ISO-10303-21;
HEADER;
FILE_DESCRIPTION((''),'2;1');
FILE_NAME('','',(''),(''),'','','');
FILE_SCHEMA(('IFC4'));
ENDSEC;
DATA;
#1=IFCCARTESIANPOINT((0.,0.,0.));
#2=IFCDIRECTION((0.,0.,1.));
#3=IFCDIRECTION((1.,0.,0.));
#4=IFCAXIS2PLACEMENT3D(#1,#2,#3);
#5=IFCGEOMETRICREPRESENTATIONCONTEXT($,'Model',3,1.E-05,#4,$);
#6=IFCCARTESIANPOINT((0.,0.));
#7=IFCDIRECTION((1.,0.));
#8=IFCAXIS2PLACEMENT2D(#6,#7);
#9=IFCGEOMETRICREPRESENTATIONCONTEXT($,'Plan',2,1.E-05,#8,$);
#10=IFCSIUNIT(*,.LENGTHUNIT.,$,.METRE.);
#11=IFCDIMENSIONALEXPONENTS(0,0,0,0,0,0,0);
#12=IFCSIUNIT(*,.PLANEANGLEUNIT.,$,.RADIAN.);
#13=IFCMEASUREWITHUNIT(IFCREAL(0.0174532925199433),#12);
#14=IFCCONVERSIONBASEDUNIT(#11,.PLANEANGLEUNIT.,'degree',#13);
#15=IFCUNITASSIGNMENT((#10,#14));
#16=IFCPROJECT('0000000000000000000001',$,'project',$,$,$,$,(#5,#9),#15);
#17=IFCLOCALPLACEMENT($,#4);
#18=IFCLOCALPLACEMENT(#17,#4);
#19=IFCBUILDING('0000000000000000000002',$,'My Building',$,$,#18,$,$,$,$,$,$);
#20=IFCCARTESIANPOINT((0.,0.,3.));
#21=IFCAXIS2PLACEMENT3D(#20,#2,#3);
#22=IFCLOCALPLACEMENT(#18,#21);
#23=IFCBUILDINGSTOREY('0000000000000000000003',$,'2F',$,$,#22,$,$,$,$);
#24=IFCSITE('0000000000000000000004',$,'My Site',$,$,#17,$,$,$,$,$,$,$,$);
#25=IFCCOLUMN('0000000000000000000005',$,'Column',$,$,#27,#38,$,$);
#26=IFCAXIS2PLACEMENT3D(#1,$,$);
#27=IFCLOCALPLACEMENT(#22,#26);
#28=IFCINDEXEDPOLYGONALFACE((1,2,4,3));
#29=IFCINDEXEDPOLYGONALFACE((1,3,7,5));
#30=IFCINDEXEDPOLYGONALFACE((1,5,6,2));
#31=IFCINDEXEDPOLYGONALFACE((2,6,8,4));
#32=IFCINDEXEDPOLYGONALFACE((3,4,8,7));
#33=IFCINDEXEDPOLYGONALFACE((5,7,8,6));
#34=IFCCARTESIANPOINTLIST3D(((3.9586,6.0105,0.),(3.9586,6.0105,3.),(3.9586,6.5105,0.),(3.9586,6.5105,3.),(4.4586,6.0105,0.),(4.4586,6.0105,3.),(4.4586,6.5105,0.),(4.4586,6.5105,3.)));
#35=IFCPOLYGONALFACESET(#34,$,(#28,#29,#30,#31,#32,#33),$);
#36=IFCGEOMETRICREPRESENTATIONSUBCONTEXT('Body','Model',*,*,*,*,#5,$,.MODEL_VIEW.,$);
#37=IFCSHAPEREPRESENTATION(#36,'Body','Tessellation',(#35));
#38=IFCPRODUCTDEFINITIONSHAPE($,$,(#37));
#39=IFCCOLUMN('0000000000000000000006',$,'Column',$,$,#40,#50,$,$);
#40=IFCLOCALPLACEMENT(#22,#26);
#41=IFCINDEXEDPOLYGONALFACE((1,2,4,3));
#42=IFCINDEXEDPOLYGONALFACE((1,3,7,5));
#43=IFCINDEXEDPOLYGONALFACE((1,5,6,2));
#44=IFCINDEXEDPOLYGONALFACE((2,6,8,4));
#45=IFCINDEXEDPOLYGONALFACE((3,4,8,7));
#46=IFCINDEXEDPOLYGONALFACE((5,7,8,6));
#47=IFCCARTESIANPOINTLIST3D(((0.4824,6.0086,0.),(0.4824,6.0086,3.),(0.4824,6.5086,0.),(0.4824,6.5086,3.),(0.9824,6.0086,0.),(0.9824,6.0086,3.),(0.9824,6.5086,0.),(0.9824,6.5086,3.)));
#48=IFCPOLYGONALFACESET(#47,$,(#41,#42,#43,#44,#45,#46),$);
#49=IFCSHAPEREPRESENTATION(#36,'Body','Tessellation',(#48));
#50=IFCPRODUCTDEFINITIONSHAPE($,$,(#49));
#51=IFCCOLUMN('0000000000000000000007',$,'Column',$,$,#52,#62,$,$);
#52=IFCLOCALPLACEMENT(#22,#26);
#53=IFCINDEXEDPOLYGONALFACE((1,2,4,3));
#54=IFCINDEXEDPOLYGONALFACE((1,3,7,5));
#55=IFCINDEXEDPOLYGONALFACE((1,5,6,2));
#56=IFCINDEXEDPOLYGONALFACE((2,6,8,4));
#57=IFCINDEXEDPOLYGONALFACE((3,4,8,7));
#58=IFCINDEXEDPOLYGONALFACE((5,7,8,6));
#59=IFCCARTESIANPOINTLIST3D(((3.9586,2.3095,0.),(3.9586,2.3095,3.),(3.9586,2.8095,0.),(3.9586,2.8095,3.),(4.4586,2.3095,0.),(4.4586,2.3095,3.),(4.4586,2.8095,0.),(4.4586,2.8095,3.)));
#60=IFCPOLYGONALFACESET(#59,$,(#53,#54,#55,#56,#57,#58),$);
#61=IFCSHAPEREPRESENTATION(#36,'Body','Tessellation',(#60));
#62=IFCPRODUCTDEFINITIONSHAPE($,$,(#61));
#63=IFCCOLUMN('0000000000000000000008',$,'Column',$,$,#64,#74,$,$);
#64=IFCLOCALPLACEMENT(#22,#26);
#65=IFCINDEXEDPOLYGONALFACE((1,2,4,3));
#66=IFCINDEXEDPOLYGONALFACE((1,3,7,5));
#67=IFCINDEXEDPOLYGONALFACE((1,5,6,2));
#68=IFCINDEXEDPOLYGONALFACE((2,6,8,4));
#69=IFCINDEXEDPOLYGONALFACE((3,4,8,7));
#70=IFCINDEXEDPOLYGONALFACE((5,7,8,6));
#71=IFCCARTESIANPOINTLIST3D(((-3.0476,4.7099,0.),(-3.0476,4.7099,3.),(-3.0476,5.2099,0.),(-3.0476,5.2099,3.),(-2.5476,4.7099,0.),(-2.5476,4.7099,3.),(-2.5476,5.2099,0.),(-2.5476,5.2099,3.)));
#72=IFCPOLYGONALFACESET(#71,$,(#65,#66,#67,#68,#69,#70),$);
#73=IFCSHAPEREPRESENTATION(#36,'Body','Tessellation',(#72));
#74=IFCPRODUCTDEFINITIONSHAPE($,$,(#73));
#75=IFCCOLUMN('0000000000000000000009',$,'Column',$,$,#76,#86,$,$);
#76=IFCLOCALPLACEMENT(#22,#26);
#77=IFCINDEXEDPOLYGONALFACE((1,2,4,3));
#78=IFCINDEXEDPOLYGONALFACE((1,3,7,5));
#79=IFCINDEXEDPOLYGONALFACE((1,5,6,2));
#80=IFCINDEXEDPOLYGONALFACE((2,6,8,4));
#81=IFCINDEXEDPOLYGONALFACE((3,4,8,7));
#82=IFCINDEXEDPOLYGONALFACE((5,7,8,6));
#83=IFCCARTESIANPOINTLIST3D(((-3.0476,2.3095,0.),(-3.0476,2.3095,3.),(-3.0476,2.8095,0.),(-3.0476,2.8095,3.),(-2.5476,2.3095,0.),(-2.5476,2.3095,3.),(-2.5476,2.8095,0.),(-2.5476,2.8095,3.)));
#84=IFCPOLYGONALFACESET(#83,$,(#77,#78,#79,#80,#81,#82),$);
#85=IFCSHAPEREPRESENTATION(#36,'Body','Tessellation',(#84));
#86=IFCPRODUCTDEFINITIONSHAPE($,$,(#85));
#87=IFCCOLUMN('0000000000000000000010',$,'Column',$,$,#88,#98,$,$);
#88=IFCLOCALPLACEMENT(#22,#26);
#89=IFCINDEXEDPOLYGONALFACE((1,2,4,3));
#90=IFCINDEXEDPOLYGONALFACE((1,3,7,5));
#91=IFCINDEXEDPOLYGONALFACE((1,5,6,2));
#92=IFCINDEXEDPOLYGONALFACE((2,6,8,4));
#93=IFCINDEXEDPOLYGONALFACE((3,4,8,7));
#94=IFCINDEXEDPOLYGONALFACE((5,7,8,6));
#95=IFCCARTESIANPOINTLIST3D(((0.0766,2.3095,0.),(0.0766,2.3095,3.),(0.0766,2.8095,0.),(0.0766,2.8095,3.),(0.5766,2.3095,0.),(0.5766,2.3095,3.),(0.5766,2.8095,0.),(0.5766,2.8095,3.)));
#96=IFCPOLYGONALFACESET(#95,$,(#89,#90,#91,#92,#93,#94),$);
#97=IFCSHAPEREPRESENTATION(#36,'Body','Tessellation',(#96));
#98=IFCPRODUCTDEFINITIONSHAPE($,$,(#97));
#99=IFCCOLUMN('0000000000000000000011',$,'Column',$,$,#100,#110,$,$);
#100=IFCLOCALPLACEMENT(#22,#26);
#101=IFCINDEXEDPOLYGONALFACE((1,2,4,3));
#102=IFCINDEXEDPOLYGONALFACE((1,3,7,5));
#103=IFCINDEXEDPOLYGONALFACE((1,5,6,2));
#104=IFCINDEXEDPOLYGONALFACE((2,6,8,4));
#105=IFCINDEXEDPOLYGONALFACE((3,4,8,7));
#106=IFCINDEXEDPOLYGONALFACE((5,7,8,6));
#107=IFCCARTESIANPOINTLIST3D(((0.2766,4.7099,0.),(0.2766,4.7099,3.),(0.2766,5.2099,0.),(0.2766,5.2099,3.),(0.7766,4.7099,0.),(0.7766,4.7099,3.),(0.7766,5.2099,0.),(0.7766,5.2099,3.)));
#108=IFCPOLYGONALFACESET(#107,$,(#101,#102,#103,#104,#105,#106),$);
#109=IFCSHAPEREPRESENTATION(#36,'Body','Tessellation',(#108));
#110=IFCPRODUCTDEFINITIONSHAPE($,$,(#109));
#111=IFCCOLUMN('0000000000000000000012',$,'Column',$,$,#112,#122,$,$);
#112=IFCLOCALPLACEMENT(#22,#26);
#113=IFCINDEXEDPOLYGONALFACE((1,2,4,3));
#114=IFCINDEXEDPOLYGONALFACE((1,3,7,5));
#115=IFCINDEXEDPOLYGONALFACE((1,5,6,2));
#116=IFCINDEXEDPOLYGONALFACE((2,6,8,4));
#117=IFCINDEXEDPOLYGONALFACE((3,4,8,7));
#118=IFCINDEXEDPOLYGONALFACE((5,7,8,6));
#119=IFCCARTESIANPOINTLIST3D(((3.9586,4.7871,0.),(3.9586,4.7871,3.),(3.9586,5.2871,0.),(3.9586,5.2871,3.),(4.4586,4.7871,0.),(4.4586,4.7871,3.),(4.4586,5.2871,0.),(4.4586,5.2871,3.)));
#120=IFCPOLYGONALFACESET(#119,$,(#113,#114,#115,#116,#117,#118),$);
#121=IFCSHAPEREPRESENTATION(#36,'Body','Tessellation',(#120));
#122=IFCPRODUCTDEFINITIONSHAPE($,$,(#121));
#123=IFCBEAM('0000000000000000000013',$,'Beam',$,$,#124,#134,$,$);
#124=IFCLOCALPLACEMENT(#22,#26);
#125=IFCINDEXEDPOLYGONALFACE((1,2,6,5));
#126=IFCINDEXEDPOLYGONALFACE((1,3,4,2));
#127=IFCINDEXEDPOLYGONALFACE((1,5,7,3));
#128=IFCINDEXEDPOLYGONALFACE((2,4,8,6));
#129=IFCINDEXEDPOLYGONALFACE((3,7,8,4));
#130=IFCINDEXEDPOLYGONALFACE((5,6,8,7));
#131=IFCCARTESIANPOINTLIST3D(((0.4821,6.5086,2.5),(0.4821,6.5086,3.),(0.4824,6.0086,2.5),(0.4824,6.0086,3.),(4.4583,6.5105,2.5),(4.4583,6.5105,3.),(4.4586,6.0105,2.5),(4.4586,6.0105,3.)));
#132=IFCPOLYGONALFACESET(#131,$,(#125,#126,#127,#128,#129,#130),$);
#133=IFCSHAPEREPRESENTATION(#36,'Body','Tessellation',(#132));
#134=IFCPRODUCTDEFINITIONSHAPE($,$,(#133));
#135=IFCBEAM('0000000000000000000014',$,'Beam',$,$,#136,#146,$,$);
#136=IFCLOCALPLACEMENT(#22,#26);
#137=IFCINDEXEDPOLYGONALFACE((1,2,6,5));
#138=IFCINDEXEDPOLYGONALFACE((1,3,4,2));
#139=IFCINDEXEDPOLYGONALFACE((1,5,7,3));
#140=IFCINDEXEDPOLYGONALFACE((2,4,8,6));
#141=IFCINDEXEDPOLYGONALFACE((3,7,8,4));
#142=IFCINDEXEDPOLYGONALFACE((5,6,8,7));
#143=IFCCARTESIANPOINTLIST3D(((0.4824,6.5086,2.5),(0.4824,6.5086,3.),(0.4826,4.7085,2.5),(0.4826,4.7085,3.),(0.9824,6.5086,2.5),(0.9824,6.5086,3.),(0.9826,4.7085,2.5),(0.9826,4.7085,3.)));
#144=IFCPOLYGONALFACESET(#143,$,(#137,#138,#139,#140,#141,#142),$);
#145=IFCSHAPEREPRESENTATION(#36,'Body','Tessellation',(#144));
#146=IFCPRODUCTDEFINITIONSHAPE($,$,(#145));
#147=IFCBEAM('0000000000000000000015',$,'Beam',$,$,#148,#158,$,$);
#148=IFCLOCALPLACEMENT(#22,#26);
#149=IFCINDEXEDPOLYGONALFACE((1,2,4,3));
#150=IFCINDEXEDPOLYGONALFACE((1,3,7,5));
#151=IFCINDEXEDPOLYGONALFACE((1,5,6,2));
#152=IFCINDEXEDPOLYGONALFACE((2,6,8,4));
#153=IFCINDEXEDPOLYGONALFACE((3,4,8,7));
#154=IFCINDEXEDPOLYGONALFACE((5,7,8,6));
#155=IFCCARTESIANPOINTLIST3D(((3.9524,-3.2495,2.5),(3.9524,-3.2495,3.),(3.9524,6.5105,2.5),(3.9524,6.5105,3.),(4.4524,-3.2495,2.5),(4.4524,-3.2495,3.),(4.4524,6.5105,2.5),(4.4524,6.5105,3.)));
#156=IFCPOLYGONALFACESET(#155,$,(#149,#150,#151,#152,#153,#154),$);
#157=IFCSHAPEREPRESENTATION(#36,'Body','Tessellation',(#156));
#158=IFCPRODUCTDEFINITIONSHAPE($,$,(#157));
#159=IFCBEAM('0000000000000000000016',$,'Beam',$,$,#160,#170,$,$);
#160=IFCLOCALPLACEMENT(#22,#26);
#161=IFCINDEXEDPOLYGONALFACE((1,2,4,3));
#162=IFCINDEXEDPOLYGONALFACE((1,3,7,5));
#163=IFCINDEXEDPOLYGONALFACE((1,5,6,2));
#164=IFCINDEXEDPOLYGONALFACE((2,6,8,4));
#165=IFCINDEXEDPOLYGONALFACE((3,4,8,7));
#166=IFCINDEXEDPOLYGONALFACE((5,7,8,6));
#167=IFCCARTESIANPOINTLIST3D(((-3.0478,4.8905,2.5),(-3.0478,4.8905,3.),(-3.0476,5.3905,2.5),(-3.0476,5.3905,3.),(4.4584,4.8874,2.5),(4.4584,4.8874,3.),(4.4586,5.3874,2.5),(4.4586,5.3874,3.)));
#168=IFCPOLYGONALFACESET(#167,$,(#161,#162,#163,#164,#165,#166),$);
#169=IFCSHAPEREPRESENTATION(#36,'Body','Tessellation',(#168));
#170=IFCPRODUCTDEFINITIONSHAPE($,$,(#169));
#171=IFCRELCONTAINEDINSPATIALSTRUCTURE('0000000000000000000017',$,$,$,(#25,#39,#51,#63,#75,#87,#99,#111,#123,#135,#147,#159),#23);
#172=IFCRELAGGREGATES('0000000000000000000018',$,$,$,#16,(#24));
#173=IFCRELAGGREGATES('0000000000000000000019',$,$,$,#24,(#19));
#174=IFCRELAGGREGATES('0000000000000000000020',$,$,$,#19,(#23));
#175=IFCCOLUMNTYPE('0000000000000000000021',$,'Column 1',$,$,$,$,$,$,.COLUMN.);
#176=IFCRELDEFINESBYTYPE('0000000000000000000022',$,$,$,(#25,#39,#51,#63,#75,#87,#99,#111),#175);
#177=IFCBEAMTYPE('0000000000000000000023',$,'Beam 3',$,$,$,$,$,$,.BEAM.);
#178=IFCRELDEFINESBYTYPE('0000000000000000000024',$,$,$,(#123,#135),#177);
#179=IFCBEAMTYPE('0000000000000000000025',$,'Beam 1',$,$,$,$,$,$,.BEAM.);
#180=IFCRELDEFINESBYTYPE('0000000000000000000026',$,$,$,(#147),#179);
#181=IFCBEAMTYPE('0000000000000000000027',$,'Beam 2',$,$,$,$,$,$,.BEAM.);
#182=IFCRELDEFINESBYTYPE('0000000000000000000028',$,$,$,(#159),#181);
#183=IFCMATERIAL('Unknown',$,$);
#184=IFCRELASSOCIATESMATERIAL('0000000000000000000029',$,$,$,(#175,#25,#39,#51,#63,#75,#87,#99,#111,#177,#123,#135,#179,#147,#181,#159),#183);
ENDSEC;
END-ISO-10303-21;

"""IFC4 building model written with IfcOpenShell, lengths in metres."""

from ifc_helpers import new_model, entity, si_unit, converted_unit, frame, origin_with_axes, origin_2d_with_axis, place, context, subcontext, project, spatial, indexed_curve, outline, extrude, material, material_profile, profile_set, profile_usage, type_object, element, save


model = new_model("IFC4")

# Units and contexts
model_context = context("Model", 3, precision=1e-05, world=origin_with_axes())
plan_context = context("Plan", 2, precision=1e-05, world=origin_2d_with_axis())
body_context_1 = subcontext(model_context, "Body", "Model", "MODEL_VIEW")
ifc_project = project(units=[si_unit("LENGTHUNIT", "METRE"), converted_unit("PLANEANGLEUNIT", "degree", entity("IfcReal", 0.0174532925199433), si_unit("PLANEANGLEUNIT", "RADIAN"), dimensions=[0, 0, 0, 0, 0, 0, 0])], contexts=[model_context, plan_context])

# Site, building, storey
site_placement = place(None, origin_with_axes())
site = spatial("IfcSite", under=ifc_project, at=site_placement, Name="My Site")
building_placement = place(site_placement, origin_with_axes())
building = spatial("IfcBuilding", under=site, at=building_placement, Name="My Building")
storey_placement = place(building_placement, frame((0.0, 0.0, 3.0), z_axis=(0.0, 0.0, 1.0), x_axis=(1.0, 0.0, 0.0)))
storey = spatial("IfcBuildingStorey", under=building, at=storey_placement, Name="2F")

# Columns
ifc_material = material(Name="Unknown")
ifc_material_profile_1 = material_profile(ifc_material, outline(indexed_curve([(-0.25, -0.25), (0.25, -0.25), (0.25, 0.25), (-0.25, 0.25), (-0.25, -0.25)])))
ifc_profile_set_1 = profile_set([ifc_material_profile_1])
ifc_profile_usage_1 = profile_usage(ifc_profile_set_1, cardinal=9)
column_type = type_object("IfcColumnType", Name="Column 1", PredefinedType="COLUMN", material=ifc_profile_set_1)
column_1_placement = place(storey_placement, frame((3.9586, 6.5105, 0.0), z_axis=(0.0, 0.0, 1.0), x_axis=(1.0, 0.0, 0.0)))
element("IfcColumn", 1, at=column_1_placement, inside=storey, type_object=column_type, material=ifc_profile_usage_1, Name="Column", context=body_context_1, shape_type="SweptSolid", body=[
    extrude(outline(indexed_curve([(-0.25, -0.25), (0.25, -0.25), (0.25, 0.25), (-0.25, 0.25), (-0.25, -0.25)])), frame((0.25, -0.25, 0.0), z_axis=(0.0, 0.0, 1.0), x_axis=(1.0, 0.0, 0.0)), (0.0, 0.0, 1.0), 3.0),
])
ifc_profile_usage_2 = profile_usage(ifc_profile_set_1, cardinal=9)
column_2_placement = place(storey_placement, frame((0.4824, 6.5086, 0.0), z_axis=(0.0, 0.0, 1.0), x_axis=(1.0, 0.0, 0.0)))
element("IfcColumn", 2, at=column_2_placement, inside=storey, type_object=column_type, material=ifc_profile_usage_2, Name="Column", context=body_context_1, shape_type="SweptSolid", body=[
    extrude(outline(indexed_curve([(-0.25, -0.25), (0.25, -0.25), (0.25, 0.25), (-0.25, 0.25), (-0.25, -0.25)])), frame((0.25, -0.25, 0.0), z_axis=(0.0, 0.0, 1.0), x_axis=(1.0, 0.0, 0.0)), (0.0, 0.0, 1.0), 3.0),
])
ifc_profile_usage_3 = profile_usage(ifc_profile_set_1, cardinal=9)
column_3_placement = place(storey_placement, frame((3.9586, 2.8095, 0.0), z_axis=(0.0, 0.0, 1.0), x_axis=(1.0, 0.0, 0.0)))
element("IfcColumn", 3, at=column_3_placement, inside=storey, type_object=column_type, material=ifc_profile_usage_3, Name="Column", context=body_context_1, shape_type="SweptSolid", body=[
    extrude(outline(indexed_curve([(-0.25, -0.25), (0.25, -0.25), (0.25, 0.25), (-0.25, 0.25), (-0.25, -0.25)])), frame((0.25, -0.25, 0.0), z_axis=(0.0, 0.0, 1.0), x_axis=(1.0, 0.0, 0.0)), (0.0, 0.0, 1.0), 3.0),
])
ifc_profile_usage_4 = profile_usage(ifc_profile_set_1, cardinal=7)
column_4_placement = place(storey_placement, frame((-2.5476, 5.2099, 0.0), z_axis=(0.0, 0.0, 1.0), x_axis=(1.0, 0.0, 0.0)))
element("IfcColumn", 4, at=column_4_placement, inside=storey, type_object=column_type, material=ifc_profile_usage_4, Name="Column", context=body_context_1, shape_type="SweptSolid", body=[
    extrude(outline(indexed_curve([(-0.25, -0.25), (0.25, -0.25), (0.25, 0.25), (-0.25, 0.25), (-0.25, -0.25)])), frame((-0.25, -0.25, 0.0), z_axis=(0.0, 0.0, 1.0), x_axis=(1.0, 0.0, 0.0)), (0.0, 0.0, 1.0), 3.0),
])
ifc_profile_usage_5 = profile_usage(ifc_profile_set_1, cardinal=7)
column_5_placement = place(storey_placement, frame((-2.5476, 2.8095, 0.0), z_axis=(0.0, 0.0, 1.0), x_axis=(1.0, 0.0, 0.0)))
element("IfcColumn", 5, at=column_5_placement, inside=storey, type_object=column_type, material=ifc_profile_usage_5, Name="Column", context=body_context_1, shape_type="SweptSolid", body=[
    extrude(outline(indexed_curve([(-0.25, -0.25), (0.25, -0.25), (0.25, 0.25), (-0.25, 0.25), (-0.25, -0.25)])), frame((-0.25, -0.25, 0.0), z_axis=(0.0, 0.0, 1.0), x_axis=(1.0, 0.0, 0.0)), (0.0, 0.0, 1.0), 3.0),
])
ifc_profile_usage_6 = profile_usage(ifc_profile_set_1, cardinal=9)
column_6_placement = place(storey_placement, frame((0.0766, 2.8095, 0.0), z_axis=(0.0, 0.0, 1.0), x_axis=(1.0, 0.0, 0.0)))
element("IfcColumn", 6, at=column_6_placement, inside=storey, type_object=column_type, material=ifc_profile_usage_6, Name="Column", context=body_context_1, shape_type="SweptSolid", body=[
    extrude(outline(indexed_curve([(-0.25, -0.25), (0.25, -0.25), (0.25, 0.25), (-0.25, 0.25), (-0.25, -0.25)])), frame((0.25, -0.25, 0.0), z_axis=(0.0, 0.0, 1.0), x_axis=(1.0, 0.0, 0.0)), (0.0, 0.0, 1.0), 3.0),
])
ifc_profile_usage_7 = profile_usage(ifc_profile_set_1, cardinal=9)
column_7_placement = place(storey_placement, frame((0.2766, 5.2099, 0.0), z_axis=(0.0, 0.0, 1.0), x_axis=(1.0, 0.0, 0.0)))
element("IfcColumn", 7, at=column_7_placement, inside=storey, type_object=column_type, material=ifc_profile_usage_7, Name="Column", context=body_context_1, shape_type="SweptSolid", body=[
    extrude(outline(indexed_curve([(-0.25, -0.25), (0.25, -0.25), (0.25, 0.25), (-0.25, 0.25), (-0.25, -0.25)])), frame((0.25, -0.25, 0.0), z_axis=(0.0, 0.0, 1.0), x_axis=(1.0, 0.0, 0.0)), (0.0, 0.0, 1.0), 3.0),
])
ifc_profile_usage_8 = profile_usage(ifc_profile_set_1, cardinal=9)
column_8_placement = place(storey_placement, frame((3.9586, 5.2871, 0.0), z_axis=(0.0, 0.0, 1.0), x_axis=(1.0, 0.0, 0.0)))
element("IfcColumn", 8, at=column_8_placement, inside=storey, type_object=column_type, material=ifc_profile_usage_8, Name="Column", context=body_context_1, shape_type="SweptSolid", body=[
    extrude(outline(indexed_curve([(-0.25, -0.25), (0.25, -0.25), (0.25, 0.25), (-0.25, 0.25), (-0.25, -0.25)])), frame((0.25, -0.25, 0.0), z_axis=(0.0, 0.0, 1.0), x_axis=(1.0, 0.0, 0.0)), (0.0, 0.0, 1.0), 3.0),
])

# Beams
ifc_material_profile_2 = material_profile(ifc_material, outline(indexed_curve([(-0.25, -0.25), (0.25, -0.25), (0.25, 0.25), (-0.25, 0.25), (-0.25, -0.25)])))
ifc_profile_set_2 = profile_set([ifc_material_profile_2])
ifc_profile_usage_9 = profile_usage(ifc_profile_set_2, cardinal=7)
beam_type_1 = type_object("IfcBeamType", Name="Beam 3", PredefinedType="BEAM", material=ifc_profile_set_2)
beam_1_placement = place(storey_placement, frame((4.4586, 6.0105, 3.0), z_axis=(-1.0, -0.000479, 0.0), x_axis=(0.000479, -1.0, 0.0)))
element("IfcBeam", 9, at=beam_1_placement, inside=storey, type_object=beam_type_1, material=ifc_profile_usage_9, Name="Beam", context=body_context_1, shape_type="SweptSolid", body=[
    extrude(outline(indexed_curve([(-0.25, -0.25), (0.25, -0.25), (0.25, 0.25), (-0.25, 0.25), (-0.25, -0.25)])), frame((-0.25, -0.25, 0.0), z_axis=(0.0, 0.0, 1.0), x_axis=(1.0, 0.0, 0.0)), (0.0, 0.0, 1.0), 3.9762),
])
ifc_profile_usage_10 = profile_usage(ifc_profile_set_2, cardinal=9)
beam_2_placement = place(storey_placement, frame((0.4824, 6.5086, 3.0), z_axis=(0.000106, -1.0, 0.000001), x_axis=(1.0, 0.000106, 0.0)))
element("IfcBeam", 10, at=beam_2_placement, inside=storey, type_object=beam_type_1, material=ifc_profile_usage_10, Name="Beam", context=body_context_1, shape_type="SweptSolid", body=[
    extrude(outline(indexed_curve([(-0.25, -0.25), (0.25, -0.25), (0.25, 0.25), (-0.25, 0.25), (-0.25, -0.25)])), frame((0.25, -0.25, 0.0), z_axis=(0.0, 0.0, 1.0), x_axis=(1.0, 0.0, 0.0)), (0.0, 0.0, 1.0), 1.8001),
])
ifc_material_profile_3 = material_profile(ifc_material, outline(indexed_curve([(-0.25, -0.25), (0.25, -0.25), (0.25, 0.25), (-0.25, 0.25), (-0.25, -0.25)])))
ifc_profile_set_3 = profile_set([ifc_material_profile_3])
ifc_profile_usage_11 = profile_usage(ifc_profile_set_3, cardinal=7)
beam_type_2 = type_object("IfcBeamType", Name="Beam 1", PredefinedType="BEAM", material=ifc_profile_set_3)
beam_3_placement = place(storey_placement, frame((4.4524, 6.5105, 3.0), z_axis=(0.0, -1.0, 0.0), x_axis=(1.0, 0.0, 0.0)))
element("IfcBeam", 11, at=beam_3_placement, inside=storey, type_object=beam_type_2, material=ifc_profile_usage_11, Name="Beam", context=body_context_1, shape_type="SweptSolid", body=[
    extrude(outline(indexed_curve([(-0.25, -0.25), (0.25, -0.25), (0.25, 0.25), (-0.25, 0.25), (-0.25, -0.25)])), frame((-0.25, -0.25, 0.0), z_axis=(0.0, 0.0, 1.0), x_axis=(1.0, 0.0, 0.0)), (0.0, 0.0, 1.0), 9.76),
])
ifc_material_profile_4 = material_profile(ifc_material, outline(indexed_curve([(-0.25, -0.25), (0.25, -0.25), (0.25, 0.25), (-0.25, 0.25), (-0.25, -0.25)])))
ifc_profile_set_4 = profile_set([ifc_material_profile_4])
ifc_profile_usage_12 = profile_usage(ifc_profile_set_4, cardinal=7)
beam_type_3 = type_object("IfcBeamType", Name="Beam 2", PredefinedType="BEAM", material=ifc_profile_set_4)
beam_4_placement = place(storey_placement, frame((-3.0476, 5.3905, 3.0), z_axis=(1.0, -0.000402, 0.0), x_axis=(0.000402, 1.0, 0.0)))
element("IfcBeam", 12, at=beam_4_placement, inside=storey, type_object=beam_type_3, material=ifc_profile_usage_12, Name="Beam", context=body_context_1, shape_type="SweptSolid", body=[
    extrude(outline(indexed_curve([(-0.25, -0.25), (0.25, -0.25), (0.25, 0.25), (-0.25, 0.25), (-0.25, -0.25)])), frame((-0.25, -0.25, 0.0), z_axis=(0.0, 0.0, 1.0), x_axis=(1.0, 0.0, 0.0)), (0.0, 0.0, 1.0), 7.5062),
])

save(model, "model.ifc")
